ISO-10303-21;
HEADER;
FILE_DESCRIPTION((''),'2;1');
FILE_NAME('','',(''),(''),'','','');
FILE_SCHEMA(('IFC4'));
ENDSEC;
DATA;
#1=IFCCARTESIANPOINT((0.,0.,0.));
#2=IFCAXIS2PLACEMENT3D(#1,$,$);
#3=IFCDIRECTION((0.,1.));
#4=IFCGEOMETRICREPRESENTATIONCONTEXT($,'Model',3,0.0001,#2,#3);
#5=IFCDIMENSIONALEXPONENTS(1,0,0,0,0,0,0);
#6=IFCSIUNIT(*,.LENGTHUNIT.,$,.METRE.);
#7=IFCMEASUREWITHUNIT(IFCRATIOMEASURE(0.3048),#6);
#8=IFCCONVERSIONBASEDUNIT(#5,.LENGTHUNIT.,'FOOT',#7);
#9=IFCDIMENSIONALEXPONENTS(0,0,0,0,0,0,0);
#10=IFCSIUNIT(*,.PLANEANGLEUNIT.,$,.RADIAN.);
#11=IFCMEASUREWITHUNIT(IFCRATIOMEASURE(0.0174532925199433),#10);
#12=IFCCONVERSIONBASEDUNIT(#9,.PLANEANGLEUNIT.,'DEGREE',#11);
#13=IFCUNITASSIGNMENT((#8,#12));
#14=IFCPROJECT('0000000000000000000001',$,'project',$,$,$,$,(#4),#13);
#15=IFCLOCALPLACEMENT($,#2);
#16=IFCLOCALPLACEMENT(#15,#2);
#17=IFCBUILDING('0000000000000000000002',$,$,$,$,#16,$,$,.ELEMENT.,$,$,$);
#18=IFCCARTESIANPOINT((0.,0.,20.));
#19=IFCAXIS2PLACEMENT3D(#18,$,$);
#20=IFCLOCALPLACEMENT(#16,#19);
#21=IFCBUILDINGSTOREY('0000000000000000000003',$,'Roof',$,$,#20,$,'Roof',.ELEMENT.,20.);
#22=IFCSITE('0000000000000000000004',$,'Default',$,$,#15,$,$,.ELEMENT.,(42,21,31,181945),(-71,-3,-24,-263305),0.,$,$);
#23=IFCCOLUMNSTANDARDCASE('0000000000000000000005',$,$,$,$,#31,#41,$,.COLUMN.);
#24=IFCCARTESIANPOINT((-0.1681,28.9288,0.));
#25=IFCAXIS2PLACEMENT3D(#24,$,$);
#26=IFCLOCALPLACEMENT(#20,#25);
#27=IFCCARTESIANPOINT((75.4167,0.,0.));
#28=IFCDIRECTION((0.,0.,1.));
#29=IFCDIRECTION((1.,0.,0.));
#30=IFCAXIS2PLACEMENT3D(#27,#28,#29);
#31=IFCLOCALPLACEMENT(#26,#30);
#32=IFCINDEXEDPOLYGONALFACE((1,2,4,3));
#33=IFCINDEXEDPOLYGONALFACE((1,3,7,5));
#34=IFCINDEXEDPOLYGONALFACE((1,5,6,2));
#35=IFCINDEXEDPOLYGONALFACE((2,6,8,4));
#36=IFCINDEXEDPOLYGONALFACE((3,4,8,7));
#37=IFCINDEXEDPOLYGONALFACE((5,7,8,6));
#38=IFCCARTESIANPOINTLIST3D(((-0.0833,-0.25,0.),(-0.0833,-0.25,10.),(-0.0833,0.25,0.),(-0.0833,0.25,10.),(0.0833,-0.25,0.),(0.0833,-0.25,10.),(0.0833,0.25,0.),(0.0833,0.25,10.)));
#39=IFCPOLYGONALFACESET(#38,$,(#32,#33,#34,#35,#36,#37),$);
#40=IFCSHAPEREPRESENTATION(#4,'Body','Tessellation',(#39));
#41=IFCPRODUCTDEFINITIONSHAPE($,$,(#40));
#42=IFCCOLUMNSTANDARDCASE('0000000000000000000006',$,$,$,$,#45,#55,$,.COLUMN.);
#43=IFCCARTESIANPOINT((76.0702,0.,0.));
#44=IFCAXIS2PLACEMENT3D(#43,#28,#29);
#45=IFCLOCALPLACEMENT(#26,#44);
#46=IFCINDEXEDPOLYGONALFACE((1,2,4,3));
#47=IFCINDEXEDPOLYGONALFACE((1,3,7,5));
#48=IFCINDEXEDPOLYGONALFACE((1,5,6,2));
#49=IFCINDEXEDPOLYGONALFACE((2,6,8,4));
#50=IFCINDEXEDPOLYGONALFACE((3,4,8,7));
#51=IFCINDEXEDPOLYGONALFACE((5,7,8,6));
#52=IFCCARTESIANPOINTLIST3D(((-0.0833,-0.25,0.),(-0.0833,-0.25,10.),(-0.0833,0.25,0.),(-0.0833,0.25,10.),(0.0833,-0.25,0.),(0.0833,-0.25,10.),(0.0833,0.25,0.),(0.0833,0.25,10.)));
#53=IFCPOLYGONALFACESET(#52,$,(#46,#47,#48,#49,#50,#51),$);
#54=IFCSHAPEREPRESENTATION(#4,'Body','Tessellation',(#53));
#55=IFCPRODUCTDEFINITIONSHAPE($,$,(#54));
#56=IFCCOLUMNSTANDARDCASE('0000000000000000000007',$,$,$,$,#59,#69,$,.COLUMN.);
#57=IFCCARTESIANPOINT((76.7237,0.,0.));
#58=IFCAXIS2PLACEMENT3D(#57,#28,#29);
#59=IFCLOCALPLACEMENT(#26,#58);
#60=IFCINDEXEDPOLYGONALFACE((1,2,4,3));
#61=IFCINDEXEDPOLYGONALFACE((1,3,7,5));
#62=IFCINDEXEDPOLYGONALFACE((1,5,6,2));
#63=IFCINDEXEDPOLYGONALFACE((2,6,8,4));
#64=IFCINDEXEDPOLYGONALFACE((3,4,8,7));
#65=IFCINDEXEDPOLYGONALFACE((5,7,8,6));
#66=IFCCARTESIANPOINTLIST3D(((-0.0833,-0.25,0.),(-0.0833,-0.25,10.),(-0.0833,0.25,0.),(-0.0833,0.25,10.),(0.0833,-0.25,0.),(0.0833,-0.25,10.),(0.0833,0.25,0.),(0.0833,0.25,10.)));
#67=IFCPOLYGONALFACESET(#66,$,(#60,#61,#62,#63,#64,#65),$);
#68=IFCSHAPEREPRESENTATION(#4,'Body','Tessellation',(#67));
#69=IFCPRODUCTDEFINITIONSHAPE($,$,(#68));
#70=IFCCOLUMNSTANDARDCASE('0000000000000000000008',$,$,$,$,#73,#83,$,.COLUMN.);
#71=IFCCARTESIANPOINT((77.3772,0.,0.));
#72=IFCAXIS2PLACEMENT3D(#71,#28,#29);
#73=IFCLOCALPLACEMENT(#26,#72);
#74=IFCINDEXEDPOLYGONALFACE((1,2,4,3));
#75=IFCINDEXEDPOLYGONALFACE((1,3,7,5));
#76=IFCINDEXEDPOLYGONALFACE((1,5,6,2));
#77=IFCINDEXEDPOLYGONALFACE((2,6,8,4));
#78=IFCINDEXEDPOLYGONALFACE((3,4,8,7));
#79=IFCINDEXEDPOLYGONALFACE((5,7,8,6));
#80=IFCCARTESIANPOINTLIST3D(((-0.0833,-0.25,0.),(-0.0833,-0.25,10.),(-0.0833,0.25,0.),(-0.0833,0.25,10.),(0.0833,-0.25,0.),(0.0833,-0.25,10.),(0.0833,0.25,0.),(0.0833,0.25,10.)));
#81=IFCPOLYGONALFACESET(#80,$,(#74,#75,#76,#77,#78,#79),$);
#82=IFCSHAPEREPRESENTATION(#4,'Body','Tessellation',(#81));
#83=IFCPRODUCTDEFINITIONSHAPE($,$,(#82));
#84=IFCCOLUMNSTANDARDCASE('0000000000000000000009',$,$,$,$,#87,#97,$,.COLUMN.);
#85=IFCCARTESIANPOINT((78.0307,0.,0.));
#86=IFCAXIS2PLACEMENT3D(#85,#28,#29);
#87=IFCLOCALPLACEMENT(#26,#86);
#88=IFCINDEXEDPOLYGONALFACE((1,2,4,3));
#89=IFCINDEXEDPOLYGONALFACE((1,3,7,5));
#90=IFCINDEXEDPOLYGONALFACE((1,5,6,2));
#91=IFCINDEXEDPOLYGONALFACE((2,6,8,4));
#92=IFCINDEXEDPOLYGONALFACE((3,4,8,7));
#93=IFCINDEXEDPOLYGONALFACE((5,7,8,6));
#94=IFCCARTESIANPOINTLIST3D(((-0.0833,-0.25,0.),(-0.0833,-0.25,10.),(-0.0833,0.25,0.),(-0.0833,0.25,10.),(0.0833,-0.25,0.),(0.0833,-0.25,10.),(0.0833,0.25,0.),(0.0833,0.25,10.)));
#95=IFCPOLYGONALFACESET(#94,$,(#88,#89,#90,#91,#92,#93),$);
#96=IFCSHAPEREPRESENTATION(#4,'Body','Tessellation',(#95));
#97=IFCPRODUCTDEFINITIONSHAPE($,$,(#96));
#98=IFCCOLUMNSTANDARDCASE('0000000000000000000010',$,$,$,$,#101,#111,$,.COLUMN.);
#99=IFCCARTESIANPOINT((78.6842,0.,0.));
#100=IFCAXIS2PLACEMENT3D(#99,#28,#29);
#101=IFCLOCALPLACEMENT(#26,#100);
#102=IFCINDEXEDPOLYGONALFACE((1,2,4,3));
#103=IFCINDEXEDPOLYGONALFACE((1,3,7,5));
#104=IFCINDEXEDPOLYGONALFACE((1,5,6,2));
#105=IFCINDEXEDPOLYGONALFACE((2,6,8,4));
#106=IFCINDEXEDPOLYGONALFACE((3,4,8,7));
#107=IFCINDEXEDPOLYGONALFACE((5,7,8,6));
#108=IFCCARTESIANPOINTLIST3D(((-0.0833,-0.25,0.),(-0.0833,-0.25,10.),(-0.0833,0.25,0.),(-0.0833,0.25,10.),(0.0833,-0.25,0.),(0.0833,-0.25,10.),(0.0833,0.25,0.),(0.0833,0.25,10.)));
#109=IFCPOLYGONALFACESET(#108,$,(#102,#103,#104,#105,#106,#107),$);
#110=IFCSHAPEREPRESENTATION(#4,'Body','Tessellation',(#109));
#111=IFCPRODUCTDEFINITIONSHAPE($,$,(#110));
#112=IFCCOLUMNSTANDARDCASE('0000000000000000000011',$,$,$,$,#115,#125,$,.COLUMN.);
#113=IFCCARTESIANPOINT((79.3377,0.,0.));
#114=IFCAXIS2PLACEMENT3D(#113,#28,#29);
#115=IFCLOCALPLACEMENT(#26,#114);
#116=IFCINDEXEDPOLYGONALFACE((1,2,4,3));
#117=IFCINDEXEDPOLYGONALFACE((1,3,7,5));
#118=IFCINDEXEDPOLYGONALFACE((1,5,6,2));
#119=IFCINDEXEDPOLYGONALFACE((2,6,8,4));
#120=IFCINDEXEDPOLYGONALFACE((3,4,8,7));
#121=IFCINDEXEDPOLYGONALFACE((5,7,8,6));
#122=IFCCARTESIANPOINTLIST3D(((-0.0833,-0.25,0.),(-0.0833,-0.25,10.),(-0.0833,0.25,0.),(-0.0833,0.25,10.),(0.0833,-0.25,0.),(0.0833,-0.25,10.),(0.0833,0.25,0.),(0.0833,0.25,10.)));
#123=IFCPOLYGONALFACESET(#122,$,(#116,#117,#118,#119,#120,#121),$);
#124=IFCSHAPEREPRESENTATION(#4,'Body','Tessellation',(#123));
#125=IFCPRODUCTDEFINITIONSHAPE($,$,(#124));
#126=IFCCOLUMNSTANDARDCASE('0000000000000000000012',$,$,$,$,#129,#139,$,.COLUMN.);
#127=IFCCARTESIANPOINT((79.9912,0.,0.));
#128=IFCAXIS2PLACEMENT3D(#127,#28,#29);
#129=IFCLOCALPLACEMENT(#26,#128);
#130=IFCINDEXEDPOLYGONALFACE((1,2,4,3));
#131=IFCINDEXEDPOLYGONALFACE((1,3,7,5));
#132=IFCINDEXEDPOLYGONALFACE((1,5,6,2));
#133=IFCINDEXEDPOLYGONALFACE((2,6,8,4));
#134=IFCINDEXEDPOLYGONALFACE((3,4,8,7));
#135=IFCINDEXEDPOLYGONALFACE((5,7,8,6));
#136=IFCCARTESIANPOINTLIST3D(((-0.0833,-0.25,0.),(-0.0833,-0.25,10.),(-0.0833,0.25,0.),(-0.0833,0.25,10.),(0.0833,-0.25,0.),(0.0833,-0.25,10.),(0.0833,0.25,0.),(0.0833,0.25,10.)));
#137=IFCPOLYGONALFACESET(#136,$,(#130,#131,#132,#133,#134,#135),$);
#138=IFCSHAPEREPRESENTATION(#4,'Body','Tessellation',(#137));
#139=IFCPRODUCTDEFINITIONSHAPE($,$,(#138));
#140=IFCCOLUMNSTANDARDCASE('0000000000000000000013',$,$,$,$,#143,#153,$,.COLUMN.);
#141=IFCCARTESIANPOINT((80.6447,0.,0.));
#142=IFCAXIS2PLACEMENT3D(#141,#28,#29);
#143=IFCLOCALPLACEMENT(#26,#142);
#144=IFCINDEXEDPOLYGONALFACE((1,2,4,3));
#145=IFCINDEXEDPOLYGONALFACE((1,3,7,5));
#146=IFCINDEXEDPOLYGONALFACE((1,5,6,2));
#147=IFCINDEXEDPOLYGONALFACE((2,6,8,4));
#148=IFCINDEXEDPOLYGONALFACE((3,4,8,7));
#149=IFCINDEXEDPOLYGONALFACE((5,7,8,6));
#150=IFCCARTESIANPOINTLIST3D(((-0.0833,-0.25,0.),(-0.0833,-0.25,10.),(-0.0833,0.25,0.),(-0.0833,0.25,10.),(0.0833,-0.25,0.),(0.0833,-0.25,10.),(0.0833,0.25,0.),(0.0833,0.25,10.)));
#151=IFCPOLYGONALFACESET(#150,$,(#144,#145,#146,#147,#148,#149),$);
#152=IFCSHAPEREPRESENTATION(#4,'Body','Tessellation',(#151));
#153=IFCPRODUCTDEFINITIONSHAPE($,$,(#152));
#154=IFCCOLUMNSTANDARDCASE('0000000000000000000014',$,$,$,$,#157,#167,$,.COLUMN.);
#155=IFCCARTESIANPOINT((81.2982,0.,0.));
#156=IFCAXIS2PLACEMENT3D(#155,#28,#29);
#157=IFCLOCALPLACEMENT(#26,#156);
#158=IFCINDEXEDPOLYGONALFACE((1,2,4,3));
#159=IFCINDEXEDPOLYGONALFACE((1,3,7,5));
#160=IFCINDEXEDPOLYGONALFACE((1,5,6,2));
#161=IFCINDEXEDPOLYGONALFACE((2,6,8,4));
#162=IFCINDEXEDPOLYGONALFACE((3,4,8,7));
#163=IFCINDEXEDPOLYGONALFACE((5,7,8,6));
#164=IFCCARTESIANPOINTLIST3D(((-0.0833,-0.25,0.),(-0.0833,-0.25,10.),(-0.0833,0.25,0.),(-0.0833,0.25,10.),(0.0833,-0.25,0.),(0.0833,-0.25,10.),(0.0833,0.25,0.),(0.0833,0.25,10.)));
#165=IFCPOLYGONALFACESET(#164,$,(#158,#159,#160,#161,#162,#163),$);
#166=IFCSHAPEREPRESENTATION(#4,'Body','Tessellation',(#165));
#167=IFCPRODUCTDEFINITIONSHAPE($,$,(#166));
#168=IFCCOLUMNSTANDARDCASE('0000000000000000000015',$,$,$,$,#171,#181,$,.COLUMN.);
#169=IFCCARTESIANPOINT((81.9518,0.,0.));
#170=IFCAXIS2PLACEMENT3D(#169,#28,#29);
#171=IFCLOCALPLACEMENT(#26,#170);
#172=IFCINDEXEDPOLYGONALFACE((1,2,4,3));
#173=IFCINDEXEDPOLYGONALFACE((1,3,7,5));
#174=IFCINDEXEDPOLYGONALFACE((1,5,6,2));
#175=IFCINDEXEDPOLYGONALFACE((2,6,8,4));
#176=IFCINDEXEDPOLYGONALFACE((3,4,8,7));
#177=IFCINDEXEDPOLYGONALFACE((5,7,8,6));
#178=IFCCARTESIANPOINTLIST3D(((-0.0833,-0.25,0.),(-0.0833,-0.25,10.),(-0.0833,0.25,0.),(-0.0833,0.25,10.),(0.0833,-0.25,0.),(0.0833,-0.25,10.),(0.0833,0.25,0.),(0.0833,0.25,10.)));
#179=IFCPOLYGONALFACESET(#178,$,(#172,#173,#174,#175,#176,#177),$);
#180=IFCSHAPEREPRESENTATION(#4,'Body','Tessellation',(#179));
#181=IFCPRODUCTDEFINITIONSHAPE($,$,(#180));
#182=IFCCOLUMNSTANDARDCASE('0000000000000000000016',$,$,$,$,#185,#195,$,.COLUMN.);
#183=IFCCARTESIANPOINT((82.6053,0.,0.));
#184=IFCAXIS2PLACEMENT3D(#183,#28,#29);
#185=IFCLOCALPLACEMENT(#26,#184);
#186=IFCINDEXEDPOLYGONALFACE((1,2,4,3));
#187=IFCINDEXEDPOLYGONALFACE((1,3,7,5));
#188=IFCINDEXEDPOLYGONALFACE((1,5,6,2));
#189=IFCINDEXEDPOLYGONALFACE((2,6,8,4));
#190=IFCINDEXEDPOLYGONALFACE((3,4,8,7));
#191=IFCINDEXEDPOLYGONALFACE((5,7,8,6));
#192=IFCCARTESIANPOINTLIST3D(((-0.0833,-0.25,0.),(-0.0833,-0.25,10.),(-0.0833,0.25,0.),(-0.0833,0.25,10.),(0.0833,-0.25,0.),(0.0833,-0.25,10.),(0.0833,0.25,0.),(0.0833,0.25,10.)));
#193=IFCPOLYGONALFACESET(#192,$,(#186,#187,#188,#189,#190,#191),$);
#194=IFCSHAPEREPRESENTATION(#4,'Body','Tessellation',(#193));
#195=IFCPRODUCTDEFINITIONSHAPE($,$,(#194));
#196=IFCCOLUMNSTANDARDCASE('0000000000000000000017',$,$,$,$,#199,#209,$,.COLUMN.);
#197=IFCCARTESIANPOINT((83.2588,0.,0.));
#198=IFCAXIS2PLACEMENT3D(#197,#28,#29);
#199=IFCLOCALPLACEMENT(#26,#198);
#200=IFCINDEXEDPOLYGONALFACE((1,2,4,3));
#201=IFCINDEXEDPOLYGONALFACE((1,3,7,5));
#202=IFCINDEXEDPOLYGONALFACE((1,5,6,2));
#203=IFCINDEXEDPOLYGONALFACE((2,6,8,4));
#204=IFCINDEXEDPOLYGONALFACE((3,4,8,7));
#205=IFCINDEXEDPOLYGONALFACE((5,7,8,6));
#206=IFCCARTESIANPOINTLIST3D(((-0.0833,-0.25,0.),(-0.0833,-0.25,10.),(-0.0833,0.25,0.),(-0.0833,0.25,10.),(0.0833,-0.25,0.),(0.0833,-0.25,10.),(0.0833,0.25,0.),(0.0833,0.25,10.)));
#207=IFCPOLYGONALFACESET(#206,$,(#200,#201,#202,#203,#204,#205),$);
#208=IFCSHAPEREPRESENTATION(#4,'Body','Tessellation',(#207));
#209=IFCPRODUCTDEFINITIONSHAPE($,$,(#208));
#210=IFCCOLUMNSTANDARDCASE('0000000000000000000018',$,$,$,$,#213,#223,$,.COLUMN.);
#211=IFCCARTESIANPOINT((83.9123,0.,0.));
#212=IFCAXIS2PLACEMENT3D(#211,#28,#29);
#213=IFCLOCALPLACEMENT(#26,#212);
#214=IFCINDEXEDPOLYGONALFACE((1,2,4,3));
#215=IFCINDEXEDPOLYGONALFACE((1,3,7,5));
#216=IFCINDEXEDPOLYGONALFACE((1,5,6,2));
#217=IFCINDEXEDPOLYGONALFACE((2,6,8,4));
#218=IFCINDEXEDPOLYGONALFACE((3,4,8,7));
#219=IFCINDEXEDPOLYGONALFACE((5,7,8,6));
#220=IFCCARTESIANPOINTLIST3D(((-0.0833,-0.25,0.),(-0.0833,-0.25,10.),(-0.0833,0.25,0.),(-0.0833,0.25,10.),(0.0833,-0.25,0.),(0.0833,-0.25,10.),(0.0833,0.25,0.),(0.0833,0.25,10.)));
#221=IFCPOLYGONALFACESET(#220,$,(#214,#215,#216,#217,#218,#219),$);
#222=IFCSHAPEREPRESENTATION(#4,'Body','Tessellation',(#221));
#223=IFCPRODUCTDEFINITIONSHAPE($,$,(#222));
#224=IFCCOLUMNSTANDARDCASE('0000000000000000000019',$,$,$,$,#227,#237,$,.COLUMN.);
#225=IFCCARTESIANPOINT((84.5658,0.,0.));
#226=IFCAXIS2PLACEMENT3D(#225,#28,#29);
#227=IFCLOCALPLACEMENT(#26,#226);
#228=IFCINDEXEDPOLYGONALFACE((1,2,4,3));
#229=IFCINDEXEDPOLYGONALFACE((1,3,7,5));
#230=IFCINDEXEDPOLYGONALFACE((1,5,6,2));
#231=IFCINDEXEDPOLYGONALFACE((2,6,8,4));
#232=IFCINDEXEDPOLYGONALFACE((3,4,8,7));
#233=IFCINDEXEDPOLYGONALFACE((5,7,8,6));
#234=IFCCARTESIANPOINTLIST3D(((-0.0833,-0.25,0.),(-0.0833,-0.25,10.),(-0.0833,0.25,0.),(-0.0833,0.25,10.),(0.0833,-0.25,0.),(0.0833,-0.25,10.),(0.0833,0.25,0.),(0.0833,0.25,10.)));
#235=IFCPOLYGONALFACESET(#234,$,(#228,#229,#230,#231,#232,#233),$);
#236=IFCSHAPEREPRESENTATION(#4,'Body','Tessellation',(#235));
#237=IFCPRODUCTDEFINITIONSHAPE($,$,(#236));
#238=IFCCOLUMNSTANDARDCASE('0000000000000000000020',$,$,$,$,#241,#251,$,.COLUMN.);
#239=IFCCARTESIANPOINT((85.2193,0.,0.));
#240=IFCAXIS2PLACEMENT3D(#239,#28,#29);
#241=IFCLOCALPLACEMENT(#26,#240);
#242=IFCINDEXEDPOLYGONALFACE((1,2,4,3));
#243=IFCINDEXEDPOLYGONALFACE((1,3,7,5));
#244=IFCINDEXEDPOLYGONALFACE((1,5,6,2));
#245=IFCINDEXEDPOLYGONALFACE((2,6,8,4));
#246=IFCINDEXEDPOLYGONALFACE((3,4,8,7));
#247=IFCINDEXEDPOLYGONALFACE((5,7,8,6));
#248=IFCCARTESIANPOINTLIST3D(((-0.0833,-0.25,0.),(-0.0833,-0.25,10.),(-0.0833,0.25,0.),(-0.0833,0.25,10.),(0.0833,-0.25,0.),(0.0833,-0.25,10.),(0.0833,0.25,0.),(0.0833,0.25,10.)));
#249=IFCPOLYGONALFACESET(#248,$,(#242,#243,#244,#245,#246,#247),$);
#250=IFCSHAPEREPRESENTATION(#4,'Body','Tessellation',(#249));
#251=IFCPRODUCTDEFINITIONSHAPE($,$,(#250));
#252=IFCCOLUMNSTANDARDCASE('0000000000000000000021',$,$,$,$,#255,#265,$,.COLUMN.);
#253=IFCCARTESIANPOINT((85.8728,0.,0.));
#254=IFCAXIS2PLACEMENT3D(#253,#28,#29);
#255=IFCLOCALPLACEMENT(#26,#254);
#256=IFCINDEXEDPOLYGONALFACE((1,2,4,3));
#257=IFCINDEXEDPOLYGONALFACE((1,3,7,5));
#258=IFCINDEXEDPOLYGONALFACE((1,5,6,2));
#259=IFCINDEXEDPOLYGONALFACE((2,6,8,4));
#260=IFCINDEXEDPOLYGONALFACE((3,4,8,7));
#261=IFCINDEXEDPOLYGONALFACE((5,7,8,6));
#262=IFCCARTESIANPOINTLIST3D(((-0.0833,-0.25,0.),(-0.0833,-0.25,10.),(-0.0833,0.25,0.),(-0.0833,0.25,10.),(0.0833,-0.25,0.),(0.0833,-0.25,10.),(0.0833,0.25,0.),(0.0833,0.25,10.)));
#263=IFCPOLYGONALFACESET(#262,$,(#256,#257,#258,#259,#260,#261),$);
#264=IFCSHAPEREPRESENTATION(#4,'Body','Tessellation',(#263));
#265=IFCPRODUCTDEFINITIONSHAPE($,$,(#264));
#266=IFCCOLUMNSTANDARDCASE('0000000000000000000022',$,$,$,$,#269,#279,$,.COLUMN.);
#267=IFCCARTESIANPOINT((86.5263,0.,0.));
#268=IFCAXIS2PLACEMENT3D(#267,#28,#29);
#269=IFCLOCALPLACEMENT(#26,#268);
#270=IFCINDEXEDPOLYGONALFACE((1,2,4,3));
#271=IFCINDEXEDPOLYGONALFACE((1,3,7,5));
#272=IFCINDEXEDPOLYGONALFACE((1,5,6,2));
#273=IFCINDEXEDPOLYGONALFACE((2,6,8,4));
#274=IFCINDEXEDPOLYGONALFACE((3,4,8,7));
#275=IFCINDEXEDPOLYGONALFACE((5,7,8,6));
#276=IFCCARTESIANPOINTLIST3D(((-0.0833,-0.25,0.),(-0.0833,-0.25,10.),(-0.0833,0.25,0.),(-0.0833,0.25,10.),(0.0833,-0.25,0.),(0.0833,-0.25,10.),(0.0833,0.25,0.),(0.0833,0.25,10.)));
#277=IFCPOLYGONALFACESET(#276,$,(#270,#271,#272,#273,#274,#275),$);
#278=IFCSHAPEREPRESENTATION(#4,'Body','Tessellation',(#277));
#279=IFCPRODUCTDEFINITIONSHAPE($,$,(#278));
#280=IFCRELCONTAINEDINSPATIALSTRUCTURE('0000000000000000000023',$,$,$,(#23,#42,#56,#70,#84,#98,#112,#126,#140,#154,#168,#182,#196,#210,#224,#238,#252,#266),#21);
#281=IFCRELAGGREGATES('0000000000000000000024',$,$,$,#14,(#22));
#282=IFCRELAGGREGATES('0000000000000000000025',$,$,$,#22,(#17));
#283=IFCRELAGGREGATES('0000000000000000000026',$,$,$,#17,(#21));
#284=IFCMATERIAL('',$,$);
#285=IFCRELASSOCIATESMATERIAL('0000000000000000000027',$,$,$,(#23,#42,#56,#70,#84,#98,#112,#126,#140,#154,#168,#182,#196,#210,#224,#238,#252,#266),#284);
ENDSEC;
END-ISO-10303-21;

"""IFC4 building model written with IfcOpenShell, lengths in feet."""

from ifc_helpers import new_model, entity, si_unit, converted_unit, direction, frame, origin, place, context, project, spatial, rectangle, extrude, material, element, save


model = new_model("IFC4")

# Units and contexts
model_context = context("Model", 3, precision=0.0001, world=origin(), true_north=direction((0.0, 1.0)))
ifc_project = project(units=[converted_unit("LENGTHUNIT", "FOOT", entity("IfcRatioMeasure", 0.3048), si_unit("LENGTHUNIT", "METRE"), dimensions=[1, 0, 0, 0, 0, 0, 0]), converted_unit("PLANEANGLEUNIT", "DEGREE", entity("IfcRatioMeasure", 0.0174532925199433), si_unit("PLANEANGLEUNIT", "RADIAN"), dimensions=[0, 0, 0, 0, 0, 0, 0])], contexts=[model_context])

# Site, building, storey
site_placement = place(None, origin())
site = spatial("IfcSite", under=ifc_project, at=site_placement, Name="Default", CompositionType="ELEMENT", RefLatitude=(42, 21, 31, 181945), RefLongitude=(-71, -3, -24, -263305), RefElevation=0.0)
building_placement = place(site_placement, origin())
building = spatial("IfcBuilding", under=site, at=building_placement, CompositionType="ELEMENT")
storey_placement = place(building_placement, frame((0.0, 0.0, 20.0)))
storey = spatial("IfcBuildingStorey", under=building, at=storey_placement, Name="Roof", LongName="Roof", CompositionType="ELEMENT", Elevation=20.0)

# Columns
ifc_material_1 = material(Name="")
placement = place(storey_placement, frame((-0.1681, 28.9288, 0.0)))
for number, where, z_axis, x_axis in (
    (1, (75.4167, 0.0, 0.0), (0.0, 0.0, 1.0), (1.0, 0.0, 0.0)),
    (2, (76.0702, 0.0, 0.0), (0.0, 0.0, 1.0), (1.0, 0.0, 0.0)),
    (3, (76.7237, 0.0, 0.0), (0.0, 0.0, 1.0), (1.0, 0.0, 0.0)),
    (4, (77.3772, 0.0, 0.0), (0.0, 0.0, 1.0), (1.0, 0.0, 0.0)),
    (5, (78.0307, 0.0, 0.0), (0.0, 0.0, 1.0), (1.0, 0.0, 0.0)),
    (6, (78.6842, 0.0, 0.0), (0.0, 0.0, 1.0), (1.0, 0.0, 0.0)),
    (7, (79.3377, 0.0, 0.0), (0.0, 0.0, 1.0), (1.0, 0.0, 0.0)),
    (8, (79.9912, 0.0, 0.0), (0.0, 0.0, 1.0), (1.0, 0.0, 0.0)),
    (9, (80.6447, 0.0, 0.0), (0.0, 0.0, 1.0), (1.0, 0.0, 0.0)),
    (10, (81.2982, 0.0, 0.0), (0.0, 0.0, 1.0), (1.0, 0.0, 0.0)),
    (11, (81.9518, 0.0, 0.0), (0.0, 0.0, 1.0), (1.0, 0.0, 0.0)),
    (12, (82.6053, 0.0, 0.0), (0.0, 0.0, 1.0), (1.0, 0.0, 0.0)),
    (13, (83.2588, 0.0, 0.0), (0.0, 0.0, 1.0), (1.0, 0.0, 0.0)),
    (14, (83.9123, 0.0, 0.0), (0.0, 0.0, 1.0), (1.0, 0.0, 0.0)),
    (15, (84.5658, 0.0, 0.0), (0.0, 0.0, 1.0), (1.0, 0.0, 0.0)),
    (16, (85.2193, 0.0, 0.0), (0.0, 0.0, 1.0), (1.0, 0.0, 0.0)),
    (17, (85.8728, 0.0, 0.0), (0.0, 0.0, 1.0), (1.0, 0.0, 0.0)),
    (18, (86.5263, 0.0, 0.0), (0.0, 0.0, 1.0), (1.0, 0.0, 0.0)),
):
    element("IfcColumnStandardCase", number, at=place(placement, frame(where, z_axis=z_axis, x_axis=x_axis)), inside=storey, material=ifc_material_1, PredefinedType="COLUMN", context=model_context, shape_type="SweptSolid", body=[
        extrude(rectangle(XDim=0.1667, YDim=0.5), origin(), (0.0, 0.0, 1.0), 10.0),
    ])

save(model, "model.ifc")
